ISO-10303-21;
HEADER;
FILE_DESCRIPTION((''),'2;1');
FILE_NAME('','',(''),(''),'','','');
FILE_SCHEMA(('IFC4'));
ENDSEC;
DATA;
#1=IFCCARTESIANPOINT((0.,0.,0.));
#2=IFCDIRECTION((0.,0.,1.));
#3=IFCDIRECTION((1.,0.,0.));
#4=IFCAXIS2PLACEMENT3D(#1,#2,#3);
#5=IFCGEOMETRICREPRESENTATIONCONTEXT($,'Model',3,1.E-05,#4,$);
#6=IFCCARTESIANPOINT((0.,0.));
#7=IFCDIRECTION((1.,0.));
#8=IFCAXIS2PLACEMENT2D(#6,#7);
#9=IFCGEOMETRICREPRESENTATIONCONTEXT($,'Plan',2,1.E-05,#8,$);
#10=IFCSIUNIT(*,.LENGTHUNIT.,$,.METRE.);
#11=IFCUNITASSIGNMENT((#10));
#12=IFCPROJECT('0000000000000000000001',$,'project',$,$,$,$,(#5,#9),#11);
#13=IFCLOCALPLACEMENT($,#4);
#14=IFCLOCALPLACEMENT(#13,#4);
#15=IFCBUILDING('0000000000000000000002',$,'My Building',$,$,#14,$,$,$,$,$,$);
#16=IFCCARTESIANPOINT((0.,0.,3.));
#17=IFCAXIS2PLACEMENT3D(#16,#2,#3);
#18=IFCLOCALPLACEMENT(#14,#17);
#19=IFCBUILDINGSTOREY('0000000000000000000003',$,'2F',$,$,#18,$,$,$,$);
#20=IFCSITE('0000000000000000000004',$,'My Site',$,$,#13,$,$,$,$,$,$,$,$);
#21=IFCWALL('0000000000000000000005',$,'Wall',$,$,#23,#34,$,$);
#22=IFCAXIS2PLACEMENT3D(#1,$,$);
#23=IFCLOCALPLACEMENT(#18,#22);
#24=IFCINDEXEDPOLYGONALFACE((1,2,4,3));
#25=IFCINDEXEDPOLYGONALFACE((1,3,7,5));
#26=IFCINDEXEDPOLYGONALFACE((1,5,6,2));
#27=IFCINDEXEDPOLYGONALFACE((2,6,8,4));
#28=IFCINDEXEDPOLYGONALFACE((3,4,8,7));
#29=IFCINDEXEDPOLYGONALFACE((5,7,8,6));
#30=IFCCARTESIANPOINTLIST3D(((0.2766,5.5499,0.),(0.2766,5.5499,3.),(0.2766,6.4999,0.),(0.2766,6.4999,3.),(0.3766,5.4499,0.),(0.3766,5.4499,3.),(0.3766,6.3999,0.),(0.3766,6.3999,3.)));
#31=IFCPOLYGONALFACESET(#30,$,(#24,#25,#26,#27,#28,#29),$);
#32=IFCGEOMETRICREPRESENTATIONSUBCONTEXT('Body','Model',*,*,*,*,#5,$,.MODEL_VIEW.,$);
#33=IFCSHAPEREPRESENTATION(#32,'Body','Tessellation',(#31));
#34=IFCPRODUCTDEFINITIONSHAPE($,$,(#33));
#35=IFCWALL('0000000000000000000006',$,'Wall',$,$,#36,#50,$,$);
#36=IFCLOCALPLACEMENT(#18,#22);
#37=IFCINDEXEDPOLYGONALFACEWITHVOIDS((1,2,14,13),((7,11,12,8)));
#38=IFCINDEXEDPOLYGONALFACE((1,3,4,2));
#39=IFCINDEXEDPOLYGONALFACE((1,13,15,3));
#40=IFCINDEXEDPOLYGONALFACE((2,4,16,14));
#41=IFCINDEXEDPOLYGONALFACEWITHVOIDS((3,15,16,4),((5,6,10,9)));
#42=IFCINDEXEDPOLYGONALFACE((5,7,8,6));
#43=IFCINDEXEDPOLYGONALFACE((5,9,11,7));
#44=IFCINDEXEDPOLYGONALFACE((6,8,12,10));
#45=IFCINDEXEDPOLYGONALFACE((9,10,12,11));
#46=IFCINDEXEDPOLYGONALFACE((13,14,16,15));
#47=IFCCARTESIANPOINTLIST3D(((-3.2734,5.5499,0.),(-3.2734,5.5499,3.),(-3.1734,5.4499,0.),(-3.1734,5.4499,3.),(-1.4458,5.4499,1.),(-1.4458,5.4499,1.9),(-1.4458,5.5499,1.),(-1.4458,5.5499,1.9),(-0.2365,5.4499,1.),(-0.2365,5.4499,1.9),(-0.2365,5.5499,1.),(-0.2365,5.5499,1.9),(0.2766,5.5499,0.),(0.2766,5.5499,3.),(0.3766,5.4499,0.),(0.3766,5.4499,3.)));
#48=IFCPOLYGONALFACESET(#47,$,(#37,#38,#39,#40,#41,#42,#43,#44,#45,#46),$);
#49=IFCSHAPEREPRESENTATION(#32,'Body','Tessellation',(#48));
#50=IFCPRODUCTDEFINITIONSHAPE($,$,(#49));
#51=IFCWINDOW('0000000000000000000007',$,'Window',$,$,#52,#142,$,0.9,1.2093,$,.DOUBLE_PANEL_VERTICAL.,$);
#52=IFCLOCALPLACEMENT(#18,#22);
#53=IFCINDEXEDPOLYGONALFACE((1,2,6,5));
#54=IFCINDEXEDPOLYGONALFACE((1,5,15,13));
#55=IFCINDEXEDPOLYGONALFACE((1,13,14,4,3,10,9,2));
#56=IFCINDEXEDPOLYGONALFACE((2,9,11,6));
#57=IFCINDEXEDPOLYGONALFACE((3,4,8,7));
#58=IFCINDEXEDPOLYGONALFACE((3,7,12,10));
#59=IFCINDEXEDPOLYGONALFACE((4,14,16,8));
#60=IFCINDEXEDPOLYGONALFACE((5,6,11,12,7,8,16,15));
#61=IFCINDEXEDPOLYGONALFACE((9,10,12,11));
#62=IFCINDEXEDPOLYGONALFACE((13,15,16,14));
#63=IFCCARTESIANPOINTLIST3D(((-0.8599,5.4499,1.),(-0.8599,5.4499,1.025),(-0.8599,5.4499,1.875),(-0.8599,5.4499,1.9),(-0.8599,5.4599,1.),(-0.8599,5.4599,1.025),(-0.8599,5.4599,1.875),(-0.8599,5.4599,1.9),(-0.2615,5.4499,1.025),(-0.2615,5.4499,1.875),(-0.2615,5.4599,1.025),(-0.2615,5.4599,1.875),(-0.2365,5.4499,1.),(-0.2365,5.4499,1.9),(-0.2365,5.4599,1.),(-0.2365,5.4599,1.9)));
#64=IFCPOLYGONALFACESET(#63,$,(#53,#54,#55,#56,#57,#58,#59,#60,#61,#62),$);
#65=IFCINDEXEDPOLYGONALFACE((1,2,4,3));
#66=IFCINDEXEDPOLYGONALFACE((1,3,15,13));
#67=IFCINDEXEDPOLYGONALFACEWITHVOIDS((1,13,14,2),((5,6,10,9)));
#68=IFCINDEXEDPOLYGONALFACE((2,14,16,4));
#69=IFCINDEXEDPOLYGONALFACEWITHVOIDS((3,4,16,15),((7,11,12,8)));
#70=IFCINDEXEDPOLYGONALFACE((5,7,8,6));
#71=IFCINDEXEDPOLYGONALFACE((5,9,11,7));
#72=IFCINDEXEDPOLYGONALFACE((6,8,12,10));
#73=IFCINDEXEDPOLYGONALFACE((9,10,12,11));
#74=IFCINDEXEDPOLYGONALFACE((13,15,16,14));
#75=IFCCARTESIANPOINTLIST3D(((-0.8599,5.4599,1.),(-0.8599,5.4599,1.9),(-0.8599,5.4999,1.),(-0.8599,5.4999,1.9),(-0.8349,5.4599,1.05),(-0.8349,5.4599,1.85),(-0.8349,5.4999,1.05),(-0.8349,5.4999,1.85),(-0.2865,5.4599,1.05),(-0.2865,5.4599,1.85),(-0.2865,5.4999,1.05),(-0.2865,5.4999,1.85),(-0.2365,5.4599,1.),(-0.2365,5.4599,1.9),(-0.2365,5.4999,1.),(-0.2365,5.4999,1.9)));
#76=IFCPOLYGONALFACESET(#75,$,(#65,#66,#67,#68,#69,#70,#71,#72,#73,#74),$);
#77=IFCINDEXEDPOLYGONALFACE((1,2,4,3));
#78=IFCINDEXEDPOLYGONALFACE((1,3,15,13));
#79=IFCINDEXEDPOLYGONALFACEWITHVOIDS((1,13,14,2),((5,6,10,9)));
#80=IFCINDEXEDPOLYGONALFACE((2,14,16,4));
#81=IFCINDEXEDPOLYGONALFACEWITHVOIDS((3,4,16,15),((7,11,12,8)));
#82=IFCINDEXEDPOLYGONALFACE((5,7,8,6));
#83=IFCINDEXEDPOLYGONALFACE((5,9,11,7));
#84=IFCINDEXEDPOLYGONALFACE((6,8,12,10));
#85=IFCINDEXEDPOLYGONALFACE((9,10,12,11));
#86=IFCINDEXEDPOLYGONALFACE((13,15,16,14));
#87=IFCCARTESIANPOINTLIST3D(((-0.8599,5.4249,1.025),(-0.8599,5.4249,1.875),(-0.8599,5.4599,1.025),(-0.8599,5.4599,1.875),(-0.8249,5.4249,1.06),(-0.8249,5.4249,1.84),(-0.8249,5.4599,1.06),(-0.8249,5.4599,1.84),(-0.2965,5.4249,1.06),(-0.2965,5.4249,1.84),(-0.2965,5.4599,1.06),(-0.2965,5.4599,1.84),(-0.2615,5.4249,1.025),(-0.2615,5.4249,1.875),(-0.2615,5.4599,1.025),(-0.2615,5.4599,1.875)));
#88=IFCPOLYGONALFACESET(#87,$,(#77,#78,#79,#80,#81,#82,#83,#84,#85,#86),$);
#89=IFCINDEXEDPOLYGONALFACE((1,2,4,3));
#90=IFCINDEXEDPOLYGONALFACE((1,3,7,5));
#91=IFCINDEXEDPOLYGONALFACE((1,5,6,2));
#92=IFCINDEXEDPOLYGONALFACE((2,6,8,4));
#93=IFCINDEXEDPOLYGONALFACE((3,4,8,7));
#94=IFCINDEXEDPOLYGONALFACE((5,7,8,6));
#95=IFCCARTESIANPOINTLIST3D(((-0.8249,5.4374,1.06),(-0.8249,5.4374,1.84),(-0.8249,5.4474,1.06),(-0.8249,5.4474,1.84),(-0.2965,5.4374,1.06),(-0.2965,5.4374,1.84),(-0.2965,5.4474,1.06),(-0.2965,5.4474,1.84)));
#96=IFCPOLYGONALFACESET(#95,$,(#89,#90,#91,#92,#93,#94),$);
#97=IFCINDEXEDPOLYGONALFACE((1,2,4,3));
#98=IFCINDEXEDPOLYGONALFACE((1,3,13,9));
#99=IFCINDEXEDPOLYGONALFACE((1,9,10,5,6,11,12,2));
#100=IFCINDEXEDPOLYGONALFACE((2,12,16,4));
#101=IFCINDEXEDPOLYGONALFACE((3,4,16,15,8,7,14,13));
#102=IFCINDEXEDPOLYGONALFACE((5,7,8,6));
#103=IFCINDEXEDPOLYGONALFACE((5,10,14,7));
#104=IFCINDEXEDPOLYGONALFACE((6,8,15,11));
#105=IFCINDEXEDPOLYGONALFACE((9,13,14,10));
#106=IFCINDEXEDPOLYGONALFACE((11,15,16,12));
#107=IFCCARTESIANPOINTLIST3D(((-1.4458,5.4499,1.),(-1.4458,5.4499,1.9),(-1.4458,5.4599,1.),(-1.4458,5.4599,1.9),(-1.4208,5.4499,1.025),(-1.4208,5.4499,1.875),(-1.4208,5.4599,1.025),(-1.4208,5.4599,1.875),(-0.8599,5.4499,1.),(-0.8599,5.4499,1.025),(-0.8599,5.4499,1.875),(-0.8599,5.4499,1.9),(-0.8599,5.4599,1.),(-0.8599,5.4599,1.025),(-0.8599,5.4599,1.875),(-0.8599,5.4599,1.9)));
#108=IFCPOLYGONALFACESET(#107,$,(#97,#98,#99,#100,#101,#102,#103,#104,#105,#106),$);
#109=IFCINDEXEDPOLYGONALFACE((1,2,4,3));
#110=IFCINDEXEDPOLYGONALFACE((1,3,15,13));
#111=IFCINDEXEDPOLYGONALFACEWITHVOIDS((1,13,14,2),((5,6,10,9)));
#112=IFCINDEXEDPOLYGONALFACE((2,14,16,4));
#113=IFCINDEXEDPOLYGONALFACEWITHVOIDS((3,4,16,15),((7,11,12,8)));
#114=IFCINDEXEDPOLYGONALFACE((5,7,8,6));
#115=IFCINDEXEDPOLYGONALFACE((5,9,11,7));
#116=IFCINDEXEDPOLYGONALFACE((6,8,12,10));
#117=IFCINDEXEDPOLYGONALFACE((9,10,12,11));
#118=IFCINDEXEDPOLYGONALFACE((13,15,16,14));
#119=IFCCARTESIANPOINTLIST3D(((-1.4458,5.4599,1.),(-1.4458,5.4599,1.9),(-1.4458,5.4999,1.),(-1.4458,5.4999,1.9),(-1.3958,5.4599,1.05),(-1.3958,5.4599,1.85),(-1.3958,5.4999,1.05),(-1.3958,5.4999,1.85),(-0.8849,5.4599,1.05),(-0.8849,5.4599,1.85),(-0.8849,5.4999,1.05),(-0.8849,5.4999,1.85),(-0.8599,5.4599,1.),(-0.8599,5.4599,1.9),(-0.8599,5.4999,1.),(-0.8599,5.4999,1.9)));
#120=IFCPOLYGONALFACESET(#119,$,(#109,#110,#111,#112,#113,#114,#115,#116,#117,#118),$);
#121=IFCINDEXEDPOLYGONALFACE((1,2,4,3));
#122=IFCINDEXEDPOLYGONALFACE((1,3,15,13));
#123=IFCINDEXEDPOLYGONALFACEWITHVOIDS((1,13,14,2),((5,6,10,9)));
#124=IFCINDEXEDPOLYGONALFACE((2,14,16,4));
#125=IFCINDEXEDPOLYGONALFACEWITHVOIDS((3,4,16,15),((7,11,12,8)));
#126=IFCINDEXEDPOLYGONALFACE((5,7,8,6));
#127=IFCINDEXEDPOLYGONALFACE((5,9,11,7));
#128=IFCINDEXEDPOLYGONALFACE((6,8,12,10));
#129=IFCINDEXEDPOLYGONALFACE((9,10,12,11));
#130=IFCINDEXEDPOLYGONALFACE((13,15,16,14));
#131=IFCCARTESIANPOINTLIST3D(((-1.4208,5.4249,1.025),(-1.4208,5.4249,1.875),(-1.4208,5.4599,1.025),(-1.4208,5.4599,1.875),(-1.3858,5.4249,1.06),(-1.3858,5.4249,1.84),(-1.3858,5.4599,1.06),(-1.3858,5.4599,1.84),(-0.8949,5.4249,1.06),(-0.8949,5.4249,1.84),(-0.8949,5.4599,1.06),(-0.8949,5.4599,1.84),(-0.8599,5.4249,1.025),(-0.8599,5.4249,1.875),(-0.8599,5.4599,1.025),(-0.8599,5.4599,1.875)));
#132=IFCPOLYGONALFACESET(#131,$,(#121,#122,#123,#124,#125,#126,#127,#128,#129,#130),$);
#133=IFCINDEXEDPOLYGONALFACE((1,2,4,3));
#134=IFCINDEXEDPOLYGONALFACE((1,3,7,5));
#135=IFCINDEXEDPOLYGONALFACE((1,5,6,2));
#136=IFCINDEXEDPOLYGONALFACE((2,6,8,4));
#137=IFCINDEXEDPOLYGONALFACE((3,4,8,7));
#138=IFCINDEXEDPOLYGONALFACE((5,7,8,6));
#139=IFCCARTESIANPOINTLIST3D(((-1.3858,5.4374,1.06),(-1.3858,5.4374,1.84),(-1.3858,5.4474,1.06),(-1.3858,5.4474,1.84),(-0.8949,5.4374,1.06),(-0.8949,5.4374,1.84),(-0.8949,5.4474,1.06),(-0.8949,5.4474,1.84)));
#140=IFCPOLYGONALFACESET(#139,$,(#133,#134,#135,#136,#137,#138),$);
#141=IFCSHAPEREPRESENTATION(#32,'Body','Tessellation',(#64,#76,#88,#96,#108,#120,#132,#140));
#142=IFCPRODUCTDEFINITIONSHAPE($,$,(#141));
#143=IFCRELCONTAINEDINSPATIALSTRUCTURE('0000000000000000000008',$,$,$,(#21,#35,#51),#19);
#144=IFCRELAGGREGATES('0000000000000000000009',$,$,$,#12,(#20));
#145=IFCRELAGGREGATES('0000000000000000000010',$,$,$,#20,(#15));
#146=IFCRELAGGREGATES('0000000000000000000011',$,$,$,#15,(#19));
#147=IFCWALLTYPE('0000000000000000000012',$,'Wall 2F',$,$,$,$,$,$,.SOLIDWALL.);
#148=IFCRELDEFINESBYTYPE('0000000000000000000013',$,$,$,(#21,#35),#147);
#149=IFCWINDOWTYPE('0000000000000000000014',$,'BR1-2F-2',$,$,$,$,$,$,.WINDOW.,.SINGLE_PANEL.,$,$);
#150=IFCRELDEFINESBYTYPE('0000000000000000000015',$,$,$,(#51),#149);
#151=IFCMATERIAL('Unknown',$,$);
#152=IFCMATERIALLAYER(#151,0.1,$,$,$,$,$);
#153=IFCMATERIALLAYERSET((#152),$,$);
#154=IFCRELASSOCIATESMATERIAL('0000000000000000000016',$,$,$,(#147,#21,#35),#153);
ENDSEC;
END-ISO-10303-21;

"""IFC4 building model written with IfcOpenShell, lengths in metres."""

from ifc_helpers import new_model, entity, si_unit, frame, origin_with_axes, origin_2d_with_axis, place, context, subcontext, project, spatial, line, indexed_curve, outline, extrude, shape, source, transform, mapped, material, layer, layer_set, layer_usage, type_object, type_shapes, element, fill, save


model = new_model("IFC4")

# Units and contexts
model_context = context("Model", 3, precision=1e-05, world=origin_with_axes())
plan_context = context("Plan", 2, precision=1e-05, world=origin_2d_with_axis())
body_context_1 = subcontext(model_context, "Body", "Model", "MODEL_VIEW")
body_context_2 = subcontext(plan_context, "Body", "Plan", "PLAN_VIEW")
ifc_project = project(units=[si_unit("LENGTHUNIT", "METRE")], contexts=[model_context, plan_context])

# Site, building, storey
site_placement = place(None, origin_with_axes())
site = spatial("IfcSite", under=ifc_project, at=site_placement, Name="My Site")
building_placement = place(site_placement, origin_with_axes())
building = spatial("IfcBuilding", under=site, at=building_placement, Name="My Building")
storey_placement = place(building_placement, frame((0.0, 0.0, 3.0), z_axis=(0.0, 0.0, 1.0), x_axis=(1.0, 0.0, 0.0)))
storey = spatial("IfcBuildingStorey", under=building, at=storey_placement, Name="2F")

# Shared definitions
ifc_material = material(Name="Unknown")

# Wall
ifc_layer = layer(ifc_material, 0.1)
ifc_layer_set = layer_set([ifc_layer])
wall_type = type_object("IfcWallType", Name="Wall 2F", PredefinedType="SOLIDWALL", material=ifc_layer_set)
ifc_layer_usage_1 = layer_usage(ifc_layer_set, "AXIS2", "POSITIVE", 0.0)
wall_1_placement = place(storey_placement, frame((0.2766, 6.4999, 0.0), z_axis=(0.0, 0.0, 1.0), x_axis=(0.0, -1.0, 0.0)))
element("IfcWall", 1, at=wall_1_placement, inside=storey, type_object=wall_type, material=ifc_layer_usage_1, Name="Wall", context=body_context_1, shape_type="SweptSolid", body=[
    extrude(outline(indexed_curve([(0.0, 0.0), (0.1, 0.1), (1.05, 0.1), (0.95, 0.0)], segments=[line(1, 2, 3, 4, 1)])), origin_with_axes(), (0.0, 0.0, 1.0), 3.0),
])

# Wall, opening, window
ifc_layer_usage_2 = layer_usage(ifc_layer_set, "AXIS2", "POSITIVE", 0.0)
wall_2_placement = place(storey_placement, frame((0.2766, 5.5499, 0.0), z_axis=(0.0, 0.0, 1.0), x_axis=(-1.0, 0.0, 0.0)))
wall_2 = element("IfcWall", 2, at=wall_2_placement, inside=storey, type_object=wall_type, material=ifc_layer_usage_2, Name="Wall", context=body_context_1, shape_type="SweptSolid", body=[
    extrude(outline(indexed_curve([(0.0, 0.0), (-0.1, 0.1), (3.45, 0.1), (3.55, 0.0)], segments=[line(1, 2, 3, 4, 1)])), origin_with_axes(), (0.0, 0.0, 1.0), 3.0),
])
shared_shape_1 = source(origin_with_axes(), body_context_1, "Body", "SweptSolid", [
    extrude(outline(indexed_curve([(0.0, 0.0), (1.2093, 0.0), (1.2093, 0.9), (0.0, 0.9)], segments=[line(1, 2, 3, 4, 1)])), frame((0.0, -0.6, 0.0), z_axis=(0.0, -1.0, 0.0), x_axis=(1.0, 0.0, 0.0)), (0.0, 0.0, -1.0), 1.2),
])
opening_1_placement = place(wall_2_placement, frame((0.5131, 0.0, 1.0), z_axis=(0.0, 0.0, 1.0), x_axis=(1.0, 0.0, 0.0)))
opening_1 = element("IfcOpeningElement", 3, at=opening_1_placement, cuts=wall_2, PredefinedType="OPENING", context=body_context_1, shape_type="MappedRepresentation", body=[
    mapped(shared_shape_1, transform((0.0, 0.0, 0.0), x_axis=(1.0, 0.0, 0.0), y_axis=(0.0, 1.0, 0.0), z_axis=(0.0, 0.0, 1.0), scale=1.0)),
])
window_type_1 = type_object("IfcWindowType", Name="BR1-2F-2", PartitioningType="SINGLE_PANEL", PredefinedType="WINDOW")
shared_shape_2 = source(origin_with_axes(), body_context_1, "Body", "SweptSolid", [
    extrude(outline(indexed_curve([(0.6234, 0.0), (0.0, 0.0), (0.0, 0.9), (0.6234, 0.9), (0.6234, 0.875), (0.025, 0.875), (0.025, 0.025), (0.6234, 0.025)], segments=[line(1, 2, 3, 4, 5, 6, 7, 8, 1)])), frame((0.0, 0.09, 0.0), z_axis=(0.0, -1.0, 0.0), x_axis=(1.0, 0.0, 0.0)), (0.0, 0.0, -1.0), 0.01),
    extrude(outline(indexed_curve([(0.0, 0.0), (0.6234, 0.0), (0.6234, 0.9), (0.0, 0.9)], segments=[line(1, 2, 3, 4, 1)]), holes=[indexed_curve([(0.05, 0.05), (0.5984, 0.05), (0.5984, 0.85), (0.05, 0.85)], segments=[line(1, 2, 3, 4, 1)])]), frame((0.0, 0.05, 0.0), z_axis=(0.0, -1.0, 0.0), x_axis=(1.0, 0.0, 0.0)), (0.0, 0.0, -1.0), 0.04),
    extrude(outline(indexed_curve([(0.0, 0.0), (0.5984, 0.0), (0.5984, 0.85), (0.0, 0.85)], segments=[line(1, 2, 3, 4, 1)]), holes=[indexed_curve([(0.035, 0.035), (0.5634, 0.035), (0.5634, 0.815), (0.035, 0.815)], segments=[line(1, 2, 3, 4, 1)])]), frame((0.025, 0.09, 0.025), z_axis=(0.0, -1.0, 0.0), x_axis=(1.0, 0.0, 0.0)), (0.0, 0.0, -1.0), 0.035),
    extrude(outline(indexed_curve([(0.035, 0.035), (0.5634, 0.035), (0.5634, 0.815), (0.035, 0.815)], segments=[line(1, 2, 3, 4, 1)])), frame((0.025, 0.1025, 0.025), z_axis=(0.0, -1.0, 0.0), x_axis=(1.0, 0.0, 0.0)), (0.0, 0.0, -1.0), 0.01),
    extrude(outline(indexed_curve([(0.0, 0.9), (0.5859, 0.9), (0.5859, 0.0), (0.0, 0.0), (0.0, 0.025), (0.5609, 0.025), (0.5609, 0.875), (0.0, 0.875)], segments=[line(1, 2, 3, 4, 5, 6, 7, 8, 1)])), frame((0.6234, 0.09, 0.0), z_axis=(0.0, -1.0, 0.0), x_axis=(1.0, 0.0, 0.0)), (0.0, 0.0, -1.0), 0.01),
    extrude(outline(indexed_curve([(0.0, 0.0), (0.5859, 0.0), (0.5859, 0.9), (0.0, 0.9)], segments=[line(1, 2, 3, 4, 1)]), holes=[indexed_curve([(0.025, 0.05), (0.5359, 0.05), (0.5359, 0.85), (0.025, 0.85)], segments=[line(1, 2, 3, 4, 1)])]), frame((0.6234, 0.05, 0.0), z_axis=(0.0, -1.0, 0.0), x_axis=(1.0, 0.0, 0.0)), (0.0, 0.0, -1.0), 0.04),
    extrude(outline(indexed_curve([(0.0, 0.0), (0.5609, 0.0), (0.5609, 0.85), (0.0, 0.85)], segments=[line(1, 2, 3, 4, 1)]), holes=[indexed_curve([(0.035, 0.035), (0.5259, 0.035), (0.5259, 0.815), (0.035, 0.815)], segments=[line(1, 2, 3, 4, 1)])]), frame((0.6234, 0.09, 0.025), z_axis=(0.0, -1.0, 0.0), x_axis=(1.0, 0.0, 0.0)), (0.0, 0.0, -1.0), 0.035),
    extrude(outline(indexed_curve([(0.035, 0.035), (0.5259, 0.035), (0.5259, 0.815), (0.035, 0.815)], segments=[line(1, 2, 3, 4, 1)])), frame((0.6234, 0.1025, 0.025), z_axis=(0.0, -1.0, 0.0), x_axis=(1.0, 0.0, 0.0)), (0.0, 0.0, -1.0), 0.01),
])
shared_shape_3 = source(origin_with_axes(), body_context_2, "Body", "Curve2D", [
    entity("IfcIndexedPolyCurve", entity("IfcCartesianPointList2D", [[0.05, 0.05], [0.5984, 0.05]])),
    entity("IfcIndexedPolyCurve", entity("IfcCartesianPointList2D", [[0.0, 0.1], [0.025, 0.1], [0.025, 0.09], [0.05, 0.09], [0.05, 0.05], [0.0, 0.05]]), [entity("IfcLineIndex", [1, 2, 3, 4, 5, 6, 1])]),
    entity("IfcIndexedPolyCurve", entity("IfcCartesianPointList2D", [[0.6234, 0.1], [0.6234, 0.1], [0.6234, 0.09], [0.5984, 0.09], [0.5984, 0.05], [0.6234, 0.05]])),
    entity("IfcIndexedPolyCurve", entity("IfcCartesianPointList2D", [[0.025, 0.09], [0.06, 0.09], [0.06, 0.125], [0.025, 0.125]]), [entity("IfcLineIndex", [1, 2, 3, 4, 1])]),
    entity("IfcIndexedPolyCurve", entity("IfcCartesianPointList2D", [[0.6234, 0.09], [0.5884, 0.09], [0.5884, 0.125], [0.6234, 0.125]]), [entity("IfcLineIndex", [1, 2, 3, 4, 1])]),
    entity("IfcIndexedPolyCurve", entity("IfcCartesianPointList2D", [[0.06, 0.09], [0.5884, 0.09]])),
    entity("IfcIndexedPolyCurve", entity("IfcCartesianPointList2D", [[0.06, 0.125], [0.5884, 0.125]])),
    entity("IfcIndexedPolyCurve", entity("IfcCartesianPointList2D", [[0.06, 0.1075], [0.5884, 0.1075]])),
    entity("IfcIndexedPolyCurve", entity("IfcCartesianPointList2D", [[0.6484, 0.05], [1.1593, 0.05]])),
    entity("IfcIndexedPolyCurve", entity("IfcCartesianPointList2D", [[0.6234, 0.1], [0.6234, 0.1], [0.6234, 0.09], [0.6484, 0.09], [0.6484, 0.05], [0.6234, 0.05]])),
    entity("IfcIndexedPolyCurve", entity("IfcCartesianPointList2D", [[1.2093, 0.1], [1.1843, 0.1], [1.1843, 0.09], [1.1593, 0.09], [1.1593, 0.05], [1.2093, 0.05]]), [entity("IfcLineIndex", [1, 2, 3, 4, 5, 6, 1])]),
    entity("IfcIndexedPolyCurve", entity("IfcCartesianPointList2D", [[0.6234, 0.09], [0.6584, 0.09], [0.6584, 0.125], [0.6234, 0.125]]), [entity("IfcLineIndex", [1, 2, 3, 4, 1])]),
    entity("IfcIndexedPolyCurve", entity("IfcCartesianPointList2D", [[1.1843, 0.09], [1.1493, 0.09], [1.1493, 0.125], [1.1843, 0.125]]), [entity("IfcLineIndex", [1, 2, 3, 4, 1])]),
    entity("IfcIndexedPolyCurve", entity("IfcCartesianPointList2D", [[0.6584, 0.09], [1.1493, 0.09]])),
    entity("IfcIndexedPolyCurve", entity("IfcCartesianPointList2D", [[0.6584, 0.125], [1.1493, 0.125]])),
    entity("IfcIndexedPolyCurve", entity("IfcCartesianPointList2D", [[0.6584, 0.1075], [1.1493, 0.1075]])),
])
type_shapes(window_type_1, [shared_shape_2, shared_shape_3])
window_1_placement = place(opening_1_placement, frame((0.0, 0.0, 0.0), z_axis=(0.0, 0.0, 1.0), x_axis=(1.0, 0.0, 0.0)))
window_1 = element("IfcWindow", 4, at=window_1_placement, inside=storey, type_object=window_type_1, Name="Window", OverallHeight=0.9, OverallWidth=1.2093, PartitioningType="DOUBLE_PANEL_VERTICAL", shapes=[
    shape(body_context_1, "Body", "MappedRepresentation", [mapped(shared_shape_2, transform((0.0, 0.0, 0.0), x_axis=(1.0, 0.0, 0.0), y_axis=(0.0, 1.0, 0.0), z_axis=(0.0, 0.0, 1.0), scale=1.0))]),
    shape(body_context_2, "Body", "MappedRepresentation", [mapped(shared_shape_3, transform((0.0, 0.0, 0.0), x_axis=(1.0, 0.0, 0.0), y_axis=(0.0, 1.0, 0.0), z_axis=(0.0, 0.0, 1.0), scale=1.0))]),
])
fill(opening_1, window_1)

save(model, "model.ifc")
